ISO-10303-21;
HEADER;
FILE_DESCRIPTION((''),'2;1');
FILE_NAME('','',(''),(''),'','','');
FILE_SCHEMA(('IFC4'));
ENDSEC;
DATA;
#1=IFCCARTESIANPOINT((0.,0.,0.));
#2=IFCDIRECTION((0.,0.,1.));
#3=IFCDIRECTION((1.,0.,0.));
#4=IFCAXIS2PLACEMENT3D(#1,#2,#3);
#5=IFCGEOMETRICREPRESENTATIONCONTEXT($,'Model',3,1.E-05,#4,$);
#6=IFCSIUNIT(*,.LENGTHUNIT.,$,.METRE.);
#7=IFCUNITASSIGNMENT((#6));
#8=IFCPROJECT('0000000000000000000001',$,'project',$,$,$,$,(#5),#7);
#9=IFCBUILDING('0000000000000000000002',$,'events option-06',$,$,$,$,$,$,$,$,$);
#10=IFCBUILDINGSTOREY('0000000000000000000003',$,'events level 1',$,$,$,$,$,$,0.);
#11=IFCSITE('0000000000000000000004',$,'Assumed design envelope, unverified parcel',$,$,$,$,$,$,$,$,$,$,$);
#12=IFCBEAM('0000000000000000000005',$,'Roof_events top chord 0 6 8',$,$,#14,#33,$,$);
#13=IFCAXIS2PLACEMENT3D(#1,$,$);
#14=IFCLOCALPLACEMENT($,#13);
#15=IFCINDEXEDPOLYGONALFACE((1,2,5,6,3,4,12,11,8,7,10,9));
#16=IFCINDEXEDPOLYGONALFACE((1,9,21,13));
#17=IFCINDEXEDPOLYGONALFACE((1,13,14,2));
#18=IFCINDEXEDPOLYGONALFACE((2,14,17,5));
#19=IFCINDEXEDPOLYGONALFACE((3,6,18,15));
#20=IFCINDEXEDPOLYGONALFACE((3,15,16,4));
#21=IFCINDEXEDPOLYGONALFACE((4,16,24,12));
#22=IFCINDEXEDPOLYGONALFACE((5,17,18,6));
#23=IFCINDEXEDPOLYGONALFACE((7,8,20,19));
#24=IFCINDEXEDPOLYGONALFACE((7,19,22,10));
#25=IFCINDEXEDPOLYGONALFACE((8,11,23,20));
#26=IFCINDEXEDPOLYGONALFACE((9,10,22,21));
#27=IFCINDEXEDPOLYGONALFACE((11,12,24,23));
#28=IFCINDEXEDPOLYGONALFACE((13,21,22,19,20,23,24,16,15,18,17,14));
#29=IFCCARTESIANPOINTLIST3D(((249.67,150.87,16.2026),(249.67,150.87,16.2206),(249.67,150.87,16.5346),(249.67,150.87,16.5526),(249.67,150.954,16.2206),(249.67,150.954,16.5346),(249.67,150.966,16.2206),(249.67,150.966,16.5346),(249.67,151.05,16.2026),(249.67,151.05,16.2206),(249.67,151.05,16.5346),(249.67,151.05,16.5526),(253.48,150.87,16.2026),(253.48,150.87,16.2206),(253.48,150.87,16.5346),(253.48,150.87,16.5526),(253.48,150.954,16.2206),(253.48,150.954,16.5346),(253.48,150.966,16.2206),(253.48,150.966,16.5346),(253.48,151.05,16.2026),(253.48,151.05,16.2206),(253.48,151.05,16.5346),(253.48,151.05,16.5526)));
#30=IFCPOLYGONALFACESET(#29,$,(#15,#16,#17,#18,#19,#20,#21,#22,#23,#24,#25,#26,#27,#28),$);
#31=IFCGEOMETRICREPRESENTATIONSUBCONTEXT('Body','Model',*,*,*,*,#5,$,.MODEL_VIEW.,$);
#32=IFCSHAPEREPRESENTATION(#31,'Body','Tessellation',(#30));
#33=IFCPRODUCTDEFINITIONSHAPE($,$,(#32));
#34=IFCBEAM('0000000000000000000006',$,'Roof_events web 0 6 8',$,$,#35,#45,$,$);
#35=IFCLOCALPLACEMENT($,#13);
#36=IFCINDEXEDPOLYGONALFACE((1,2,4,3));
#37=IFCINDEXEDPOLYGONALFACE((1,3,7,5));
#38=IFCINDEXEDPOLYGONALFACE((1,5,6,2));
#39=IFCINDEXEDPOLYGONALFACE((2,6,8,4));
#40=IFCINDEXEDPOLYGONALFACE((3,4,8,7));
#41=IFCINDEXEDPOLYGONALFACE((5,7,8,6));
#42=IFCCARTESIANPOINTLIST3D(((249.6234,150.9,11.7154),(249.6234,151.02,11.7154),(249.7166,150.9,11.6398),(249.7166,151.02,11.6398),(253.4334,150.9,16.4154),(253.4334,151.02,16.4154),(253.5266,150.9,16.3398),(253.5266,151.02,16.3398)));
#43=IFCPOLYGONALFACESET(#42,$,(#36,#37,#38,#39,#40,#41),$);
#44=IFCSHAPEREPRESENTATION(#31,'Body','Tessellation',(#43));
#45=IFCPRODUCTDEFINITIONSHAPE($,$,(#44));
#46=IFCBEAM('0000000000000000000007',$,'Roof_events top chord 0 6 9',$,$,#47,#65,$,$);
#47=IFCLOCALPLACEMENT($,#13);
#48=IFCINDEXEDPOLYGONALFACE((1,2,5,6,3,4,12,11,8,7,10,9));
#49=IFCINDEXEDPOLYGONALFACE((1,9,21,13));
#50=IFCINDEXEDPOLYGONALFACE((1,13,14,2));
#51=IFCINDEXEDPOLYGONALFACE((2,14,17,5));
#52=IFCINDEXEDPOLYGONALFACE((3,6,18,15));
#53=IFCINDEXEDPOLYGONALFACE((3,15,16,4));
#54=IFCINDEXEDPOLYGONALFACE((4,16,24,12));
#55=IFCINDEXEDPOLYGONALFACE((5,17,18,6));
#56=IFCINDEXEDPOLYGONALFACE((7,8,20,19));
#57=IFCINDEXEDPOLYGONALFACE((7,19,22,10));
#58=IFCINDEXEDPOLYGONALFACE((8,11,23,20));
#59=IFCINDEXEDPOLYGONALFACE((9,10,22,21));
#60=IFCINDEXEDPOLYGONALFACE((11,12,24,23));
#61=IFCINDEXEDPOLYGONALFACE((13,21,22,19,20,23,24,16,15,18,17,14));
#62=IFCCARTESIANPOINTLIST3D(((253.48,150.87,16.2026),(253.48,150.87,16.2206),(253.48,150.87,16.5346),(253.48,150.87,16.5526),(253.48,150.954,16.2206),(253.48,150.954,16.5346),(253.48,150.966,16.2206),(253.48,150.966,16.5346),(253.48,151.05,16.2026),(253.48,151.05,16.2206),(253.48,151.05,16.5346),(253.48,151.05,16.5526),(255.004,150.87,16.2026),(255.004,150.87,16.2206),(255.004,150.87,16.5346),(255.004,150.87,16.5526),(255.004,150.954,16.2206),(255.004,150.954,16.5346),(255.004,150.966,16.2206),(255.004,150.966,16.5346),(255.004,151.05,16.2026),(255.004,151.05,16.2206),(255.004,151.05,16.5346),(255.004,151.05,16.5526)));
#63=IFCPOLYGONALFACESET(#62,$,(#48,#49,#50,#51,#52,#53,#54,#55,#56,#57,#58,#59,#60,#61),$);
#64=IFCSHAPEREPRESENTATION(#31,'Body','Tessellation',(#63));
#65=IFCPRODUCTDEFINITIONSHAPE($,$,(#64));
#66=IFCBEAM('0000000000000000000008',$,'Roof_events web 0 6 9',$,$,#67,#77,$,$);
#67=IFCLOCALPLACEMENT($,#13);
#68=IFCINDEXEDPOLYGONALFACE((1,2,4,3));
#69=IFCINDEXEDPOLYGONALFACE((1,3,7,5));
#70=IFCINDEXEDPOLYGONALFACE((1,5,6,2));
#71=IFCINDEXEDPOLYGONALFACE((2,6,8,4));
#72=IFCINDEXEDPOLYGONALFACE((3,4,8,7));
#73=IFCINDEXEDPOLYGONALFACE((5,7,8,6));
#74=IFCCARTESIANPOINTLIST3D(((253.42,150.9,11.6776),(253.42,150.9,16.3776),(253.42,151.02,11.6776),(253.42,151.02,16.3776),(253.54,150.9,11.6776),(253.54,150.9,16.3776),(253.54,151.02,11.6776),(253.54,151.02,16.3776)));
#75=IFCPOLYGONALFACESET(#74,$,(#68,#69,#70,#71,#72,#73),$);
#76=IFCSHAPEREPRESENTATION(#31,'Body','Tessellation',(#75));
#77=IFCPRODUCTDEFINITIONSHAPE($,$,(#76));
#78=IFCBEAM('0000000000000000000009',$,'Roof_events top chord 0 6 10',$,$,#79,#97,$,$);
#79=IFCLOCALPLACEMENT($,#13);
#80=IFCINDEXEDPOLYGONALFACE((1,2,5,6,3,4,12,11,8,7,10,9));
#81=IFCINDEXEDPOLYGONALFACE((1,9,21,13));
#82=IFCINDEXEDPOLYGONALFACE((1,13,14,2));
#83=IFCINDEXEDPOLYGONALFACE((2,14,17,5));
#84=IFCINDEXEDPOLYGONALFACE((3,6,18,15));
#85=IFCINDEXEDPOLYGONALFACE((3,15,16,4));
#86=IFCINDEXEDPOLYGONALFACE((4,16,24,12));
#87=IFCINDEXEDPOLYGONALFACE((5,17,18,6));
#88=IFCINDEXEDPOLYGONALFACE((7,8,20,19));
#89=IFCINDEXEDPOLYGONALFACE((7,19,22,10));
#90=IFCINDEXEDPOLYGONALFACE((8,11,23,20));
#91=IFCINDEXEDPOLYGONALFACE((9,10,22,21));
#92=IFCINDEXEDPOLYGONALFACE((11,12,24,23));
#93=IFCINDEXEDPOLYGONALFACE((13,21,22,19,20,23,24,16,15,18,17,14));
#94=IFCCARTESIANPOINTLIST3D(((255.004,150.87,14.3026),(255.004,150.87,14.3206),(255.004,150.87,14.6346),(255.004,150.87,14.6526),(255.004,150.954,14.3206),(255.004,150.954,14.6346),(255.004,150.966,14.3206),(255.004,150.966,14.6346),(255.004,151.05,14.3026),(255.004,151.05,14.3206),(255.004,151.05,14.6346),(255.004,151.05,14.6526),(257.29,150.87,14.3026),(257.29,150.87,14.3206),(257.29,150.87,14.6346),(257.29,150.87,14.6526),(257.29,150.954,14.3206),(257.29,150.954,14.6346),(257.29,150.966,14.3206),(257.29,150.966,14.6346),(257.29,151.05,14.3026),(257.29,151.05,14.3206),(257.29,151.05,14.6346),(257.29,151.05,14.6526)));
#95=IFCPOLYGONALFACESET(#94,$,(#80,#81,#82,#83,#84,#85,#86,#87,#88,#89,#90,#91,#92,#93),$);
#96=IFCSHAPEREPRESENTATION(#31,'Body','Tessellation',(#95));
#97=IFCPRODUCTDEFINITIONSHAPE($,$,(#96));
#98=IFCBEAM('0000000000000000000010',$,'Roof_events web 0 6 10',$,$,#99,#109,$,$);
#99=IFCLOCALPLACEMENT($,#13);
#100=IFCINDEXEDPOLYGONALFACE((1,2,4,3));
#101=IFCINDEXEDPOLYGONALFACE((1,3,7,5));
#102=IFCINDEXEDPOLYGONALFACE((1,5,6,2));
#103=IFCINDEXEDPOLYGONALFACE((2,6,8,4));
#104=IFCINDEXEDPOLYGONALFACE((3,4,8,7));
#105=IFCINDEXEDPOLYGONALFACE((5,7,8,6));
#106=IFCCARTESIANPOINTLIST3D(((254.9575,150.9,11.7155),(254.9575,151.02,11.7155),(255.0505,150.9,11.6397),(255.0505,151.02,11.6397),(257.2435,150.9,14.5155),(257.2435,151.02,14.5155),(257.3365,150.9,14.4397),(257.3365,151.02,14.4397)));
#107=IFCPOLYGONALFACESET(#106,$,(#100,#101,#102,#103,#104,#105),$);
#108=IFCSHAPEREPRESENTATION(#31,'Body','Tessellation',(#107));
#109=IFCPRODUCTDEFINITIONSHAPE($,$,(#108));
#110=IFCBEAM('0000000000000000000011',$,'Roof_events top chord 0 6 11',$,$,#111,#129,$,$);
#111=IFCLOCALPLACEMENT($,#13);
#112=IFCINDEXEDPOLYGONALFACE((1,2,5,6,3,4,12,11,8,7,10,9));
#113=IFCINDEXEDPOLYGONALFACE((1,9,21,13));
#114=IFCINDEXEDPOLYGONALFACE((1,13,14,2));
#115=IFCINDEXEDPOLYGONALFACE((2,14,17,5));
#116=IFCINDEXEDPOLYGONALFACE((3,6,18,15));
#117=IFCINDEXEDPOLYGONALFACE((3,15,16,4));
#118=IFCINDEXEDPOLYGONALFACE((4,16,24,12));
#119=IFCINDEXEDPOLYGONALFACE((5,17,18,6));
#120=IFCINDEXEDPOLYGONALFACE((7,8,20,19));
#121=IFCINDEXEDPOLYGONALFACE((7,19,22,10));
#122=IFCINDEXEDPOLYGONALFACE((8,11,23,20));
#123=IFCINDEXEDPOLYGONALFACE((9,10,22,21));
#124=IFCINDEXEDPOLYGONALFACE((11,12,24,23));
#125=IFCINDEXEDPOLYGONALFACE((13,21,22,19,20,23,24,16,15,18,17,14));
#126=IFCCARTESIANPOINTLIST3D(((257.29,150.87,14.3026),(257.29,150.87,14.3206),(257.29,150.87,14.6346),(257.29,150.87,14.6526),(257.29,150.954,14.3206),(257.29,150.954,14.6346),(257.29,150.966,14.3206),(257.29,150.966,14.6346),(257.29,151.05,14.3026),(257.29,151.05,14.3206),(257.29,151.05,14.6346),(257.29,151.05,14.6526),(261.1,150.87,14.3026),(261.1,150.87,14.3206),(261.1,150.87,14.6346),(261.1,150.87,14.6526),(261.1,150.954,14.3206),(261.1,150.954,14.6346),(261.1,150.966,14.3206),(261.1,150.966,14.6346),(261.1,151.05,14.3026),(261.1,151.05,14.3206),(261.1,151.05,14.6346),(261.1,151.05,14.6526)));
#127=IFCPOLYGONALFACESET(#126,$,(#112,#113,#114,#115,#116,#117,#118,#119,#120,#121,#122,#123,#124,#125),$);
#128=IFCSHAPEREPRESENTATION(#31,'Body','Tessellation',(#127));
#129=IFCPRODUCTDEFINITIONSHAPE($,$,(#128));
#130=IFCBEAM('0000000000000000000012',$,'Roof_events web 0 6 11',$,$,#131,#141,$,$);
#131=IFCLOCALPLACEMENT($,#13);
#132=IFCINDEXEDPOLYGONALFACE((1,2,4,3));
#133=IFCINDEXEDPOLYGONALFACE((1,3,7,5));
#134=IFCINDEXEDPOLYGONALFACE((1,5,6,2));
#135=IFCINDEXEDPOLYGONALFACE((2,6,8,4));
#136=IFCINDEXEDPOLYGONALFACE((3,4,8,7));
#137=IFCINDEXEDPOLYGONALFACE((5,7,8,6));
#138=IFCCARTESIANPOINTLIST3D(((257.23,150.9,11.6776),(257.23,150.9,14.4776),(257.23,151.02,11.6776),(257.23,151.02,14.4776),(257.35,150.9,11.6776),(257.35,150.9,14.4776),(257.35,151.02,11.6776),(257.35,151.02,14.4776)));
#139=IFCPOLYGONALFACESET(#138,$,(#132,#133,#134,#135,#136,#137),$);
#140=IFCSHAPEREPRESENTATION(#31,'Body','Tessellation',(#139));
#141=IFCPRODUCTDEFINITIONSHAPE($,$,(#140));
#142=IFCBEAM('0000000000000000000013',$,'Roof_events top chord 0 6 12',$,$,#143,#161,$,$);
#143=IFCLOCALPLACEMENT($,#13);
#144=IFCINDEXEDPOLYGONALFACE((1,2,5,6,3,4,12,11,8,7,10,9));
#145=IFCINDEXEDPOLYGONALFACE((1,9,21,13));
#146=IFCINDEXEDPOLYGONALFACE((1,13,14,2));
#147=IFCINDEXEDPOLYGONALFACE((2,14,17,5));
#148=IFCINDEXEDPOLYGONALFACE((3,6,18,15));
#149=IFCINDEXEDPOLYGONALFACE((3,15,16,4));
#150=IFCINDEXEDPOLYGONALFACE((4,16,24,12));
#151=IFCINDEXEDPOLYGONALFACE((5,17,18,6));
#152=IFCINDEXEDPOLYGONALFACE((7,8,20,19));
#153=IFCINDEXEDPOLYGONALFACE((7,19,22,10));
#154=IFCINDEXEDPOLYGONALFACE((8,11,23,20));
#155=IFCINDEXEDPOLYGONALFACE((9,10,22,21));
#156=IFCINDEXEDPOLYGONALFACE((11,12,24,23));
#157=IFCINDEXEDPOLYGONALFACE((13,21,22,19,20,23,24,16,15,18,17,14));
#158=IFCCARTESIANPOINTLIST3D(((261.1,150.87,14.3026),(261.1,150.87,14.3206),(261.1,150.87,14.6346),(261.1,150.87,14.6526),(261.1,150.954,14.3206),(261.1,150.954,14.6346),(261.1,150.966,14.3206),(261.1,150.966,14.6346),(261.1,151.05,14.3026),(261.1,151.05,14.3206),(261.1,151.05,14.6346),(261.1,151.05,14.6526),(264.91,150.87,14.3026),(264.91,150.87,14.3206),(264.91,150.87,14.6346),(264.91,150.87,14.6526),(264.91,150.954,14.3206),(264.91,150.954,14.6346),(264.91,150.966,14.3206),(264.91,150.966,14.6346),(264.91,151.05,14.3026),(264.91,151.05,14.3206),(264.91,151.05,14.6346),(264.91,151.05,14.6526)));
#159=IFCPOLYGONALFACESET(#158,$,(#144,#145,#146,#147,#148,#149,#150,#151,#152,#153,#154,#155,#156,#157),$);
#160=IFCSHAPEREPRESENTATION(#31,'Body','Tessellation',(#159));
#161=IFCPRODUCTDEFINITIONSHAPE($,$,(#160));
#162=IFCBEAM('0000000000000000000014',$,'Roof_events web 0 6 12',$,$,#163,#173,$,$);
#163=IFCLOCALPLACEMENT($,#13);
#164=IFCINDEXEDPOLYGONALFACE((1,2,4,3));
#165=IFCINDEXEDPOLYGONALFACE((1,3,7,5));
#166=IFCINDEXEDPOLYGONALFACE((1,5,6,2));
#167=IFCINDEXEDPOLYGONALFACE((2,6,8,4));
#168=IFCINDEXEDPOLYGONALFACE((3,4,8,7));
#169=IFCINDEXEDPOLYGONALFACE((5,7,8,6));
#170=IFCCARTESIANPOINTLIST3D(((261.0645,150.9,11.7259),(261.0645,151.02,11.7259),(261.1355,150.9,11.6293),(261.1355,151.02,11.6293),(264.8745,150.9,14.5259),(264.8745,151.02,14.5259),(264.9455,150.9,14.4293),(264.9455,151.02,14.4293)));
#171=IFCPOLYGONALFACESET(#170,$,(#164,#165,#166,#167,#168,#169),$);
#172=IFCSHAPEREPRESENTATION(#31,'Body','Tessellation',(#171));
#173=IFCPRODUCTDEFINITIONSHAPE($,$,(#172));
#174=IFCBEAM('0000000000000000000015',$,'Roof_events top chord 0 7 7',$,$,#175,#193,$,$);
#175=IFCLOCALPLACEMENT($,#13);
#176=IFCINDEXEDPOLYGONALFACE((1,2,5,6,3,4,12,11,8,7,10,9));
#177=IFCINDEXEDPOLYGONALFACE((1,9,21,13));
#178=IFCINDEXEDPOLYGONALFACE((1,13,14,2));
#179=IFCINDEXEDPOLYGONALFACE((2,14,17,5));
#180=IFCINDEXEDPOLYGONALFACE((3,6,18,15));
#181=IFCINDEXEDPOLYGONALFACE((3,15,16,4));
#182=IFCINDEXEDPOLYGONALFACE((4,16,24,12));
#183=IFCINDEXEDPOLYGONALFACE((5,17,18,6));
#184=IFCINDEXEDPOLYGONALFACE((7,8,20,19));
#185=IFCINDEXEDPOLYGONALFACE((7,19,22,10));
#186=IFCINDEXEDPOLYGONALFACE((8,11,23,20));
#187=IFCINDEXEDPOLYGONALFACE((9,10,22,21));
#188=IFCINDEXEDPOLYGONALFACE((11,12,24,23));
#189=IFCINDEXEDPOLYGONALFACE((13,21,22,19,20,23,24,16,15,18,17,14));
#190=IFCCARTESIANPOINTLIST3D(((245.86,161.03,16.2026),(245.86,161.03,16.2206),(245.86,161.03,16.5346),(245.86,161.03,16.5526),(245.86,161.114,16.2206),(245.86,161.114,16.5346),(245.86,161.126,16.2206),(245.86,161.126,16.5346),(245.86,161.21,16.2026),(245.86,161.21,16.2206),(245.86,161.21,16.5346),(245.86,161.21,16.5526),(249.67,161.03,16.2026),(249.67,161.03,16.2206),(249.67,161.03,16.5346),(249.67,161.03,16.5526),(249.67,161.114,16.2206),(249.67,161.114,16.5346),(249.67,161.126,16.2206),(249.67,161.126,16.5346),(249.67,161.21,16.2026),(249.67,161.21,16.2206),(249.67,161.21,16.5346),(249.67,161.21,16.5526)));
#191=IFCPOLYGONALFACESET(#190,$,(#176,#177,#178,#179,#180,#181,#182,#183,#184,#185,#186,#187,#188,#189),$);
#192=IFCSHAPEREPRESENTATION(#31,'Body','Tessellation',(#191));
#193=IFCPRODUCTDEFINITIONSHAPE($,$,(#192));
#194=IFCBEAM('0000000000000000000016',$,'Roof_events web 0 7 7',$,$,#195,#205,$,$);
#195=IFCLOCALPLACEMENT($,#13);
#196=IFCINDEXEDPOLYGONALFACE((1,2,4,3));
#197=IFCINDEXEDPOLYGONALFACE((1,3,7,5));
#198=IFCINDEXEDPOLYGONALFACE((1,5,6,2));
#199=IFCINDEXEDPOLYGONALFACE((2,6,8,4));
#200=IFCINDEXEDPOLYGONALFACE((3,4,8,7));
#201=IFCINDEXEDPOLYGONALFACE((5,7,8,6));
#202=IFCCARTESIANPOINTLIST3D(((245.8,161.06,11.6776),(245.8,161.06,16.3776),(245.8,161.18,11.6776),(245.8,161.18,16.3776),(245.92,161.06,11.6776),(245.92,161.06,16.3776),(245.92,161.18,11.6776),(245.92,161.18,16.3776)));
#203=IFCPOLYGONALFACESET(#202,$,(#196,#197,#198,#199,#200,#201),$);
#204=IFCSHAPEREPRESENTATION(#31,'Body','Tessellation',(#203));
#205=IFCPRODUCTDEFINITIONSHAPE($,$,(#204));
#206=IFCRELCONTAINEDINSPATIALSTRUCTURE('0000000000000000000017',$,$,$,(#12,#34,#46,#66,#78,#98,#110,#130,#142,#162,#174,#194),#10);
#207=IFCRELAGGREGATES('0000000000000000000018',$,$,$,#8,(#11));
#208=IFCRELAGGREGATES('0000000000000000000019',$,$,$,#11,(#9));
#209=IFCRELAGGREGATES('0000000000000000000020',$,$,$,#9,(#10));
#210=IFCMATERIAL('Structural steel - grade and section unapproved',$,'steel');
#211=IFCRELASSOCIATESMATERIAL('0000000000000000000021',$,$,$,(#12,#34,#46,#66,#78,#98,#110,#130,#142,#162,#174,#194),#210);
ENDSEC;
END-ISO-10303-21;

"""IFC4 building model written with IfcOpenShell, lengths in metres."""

from ifc_helpers import new_model, si_unit, frame, origin_with_axes, place, context, subcontext, project, spatial, rectangle, i_section, extrude, material, element, save


model = new_model("IFC4")

# Units and contexts
model_context = context("Model", 3, precision=1e-05, world=origin_with_axes())
body_context = subcontext(model_context, "Body", "Model", "MODEL_VIEW")
ifc_project = project(units=[si_unit("LENGTHUNIT", "METRE")], contexts=[model_context])

# Site, building, storey
site = spatial("IfcSite", under=ifc_project, Name="Assumed design envelope, unverified parcel")
building = spatial("IfcBuilding", under=site, Name="events option-06")
storey = spatial("IfcBuildingStorey", under=building, Name="events level 1", Elevation=0.0)

# Beams
ifc_material = material(Name="Structural steel - grade and section unapproved", Category="steel")
beam_1_placement = place(None, frame((249.67, 150.96, 16.3776), z_axis=(1.0, 0.0, 0.0), x_axis=(0.0, 1.0, 0.0)))
element("IfcBeam", 1, at=beam_1_placement, inside=storey, material=ifc_material, Name="Roof_events top chord 0 6 8", context=body_context, shape_type="SweptSolid", body=[
    extrude(i_section(OverallWidth=0.18, OverallDepth=0.35, WebThickness=0.012, FlangeThickness=0.018, FilletRadius=0.0), origin_with_axes(), (0.0, 0.0, 1.0), 3.81),
])
beam_2_placement = place(None, frame((249.67, 150.96, 11.6776), z_axis=(0.629721, 0.0, 0.776821), x_axis=(0.0, 1.0, 0.0)))
element("IfcBeam", 2, at=beam_2_placement, inside=storey, material=ifc_material, Name="Roof_events web 0 6 8", context=body_context, shape_type="SweptSolid", body=[
    extrude(rectangle(XDim=0.12, YDim=0.12), origin_with_axes(), (0.0, 0.0, 1.0), 6.0503),
])
beam_3_placement = place(None, frame((253.48, 150.96, 16.3776), z_axis=(1.0, 0.0, 0.0), x_axis=(0.0, 1.0, 0.0)))
element("IfcBeam", 3, at=beam_3_placement, inside=storey, material=ifc_material, Name="Roof_events top chord 0 6 9", context=body_context, shape_type="SweptSolid", body=[
    extrude(i_section(OverallWidth=0.18, OverallDepth=0.35, WebThickness=0.012, FlangeThickness=0.018, FilletRadius=0.0), origin_with_axes(), (0.0, 0.0, 1.0), 1.524),
])
beam_4_placement = place(None, frame((253.48, 150.96, 11.6776), z_axis=(0.0, 0.0, 1.0), x_axis=(-1.0, 0.0, 0.0)))
element("IfcBeam", 4, at=beam_4_placement, inside=storey, material=ifc_material, Name="Roof_events web 0 6 9", context=body_context, shape_type="SweptSolid", body=[
    extrude(rectangle(XDim=0.12, YDim=0.12), origin_with_axes(), (0.0, 0.0, 1.0), 4.7),
])
beam_5_placement = place(None, frame((255.004, 150.96, 14.4776), z_axis=(1.0, 0.0, 0.0), x_axis=(0.0, 1.0, 0.0)))
element("IfcBeam", 5, at=beam_5_placement, inside=storey, material=ifc_material, Name="Roof_events top chord 0 6 10", context=body_context, shape_type="SweptSolid", body=[
    extrude(i_section(OverallWidth=0.18, OverallDepth=0.35, WebThickness=0.012, FlangeThickness=0.018, FilletRadius=0.0), origin_with_axes(), (0.0, 0.0, 1.0), 2.286),
])
beam_6_placement = place(None, frame((255.004, 150.96, 11.6776), z_axis=(0.632426, 0.0, 0.774621), x_axis=(0.0, 1.0, 0.0)))
element("IfcBeam", 6, at=beam_6_placement, inside=storey, material=ifc_material, Name="Roof_events web 0 6 10", context=body_context, shape_type="SweptSolid", body=[
    extrude(rectangle(XDim=0.12, YDim=0.12), origin_with_axes(), (0.0, 0.0, 1.0), 3.6147),
])
beam_7_placement = place(None, frame((257.29, 150.96, 14.4776), z_axis=(1.0, 0.0, 0.0), x_axis=(0.0, 1.0, 0.0)))
element("IfcBeam", 7, at=beam_7_placement, inside=storey, material=ifc_material, Name="Roof_events top chord 0 6 11", context=body_context, shape_type="SweptSolid", body=[
    extrude(i_section(OverallWidth=0.18, OverallDepth=0.35, WebThickness=0.012, FlangeThickness=0.018, FilletRadius=0.0), origin_with_axes(), (0.0, 0.0, 1.0), 3.81),
])
beam_8_placement = place(None, frame((257.29, 150.96, 11.6776), z_axis=(0.0, 0.0, 1.0), x_axis=(-1.0, 0.0, 0.0)))
element("IfcBeam", 8, at=beam_8_placement, inside=storey, material=ifc_material, Name="Roof_events web 0 6 11", context=body_context, shape_type="SweptSolid", body=[
    extrude(rectangle(XDim=0.12, YDim=0.12), origin_with_axes(), (0.0, 0.0, 1.0), 2.8),
])
beam_9_placement = place(None, frame((261.1, 150.96, 14.4776), z_axis=(1.0, 0.0, 0.0), x_axis=(0.0, 1.0, 0.0)))
element("IfcBeam", 9, at=beam_9_placement, inside=storey, material=ifc_material, Name="Roof_events top chord 0 6 12", context=body_context, shape_type="SweptSolid", body=[
    extrude(i_section(OverallWidth=0.18, OverallDepth=0.35, WebThickness=0.012, FlangeThickness=0.018, FilletRadius=0.0), origin_with_axes(), (0.0, 0.0, 1.0), 3.81),
])
beam_10_placement = place(None, frame((261.1, 150.96, 11.6776), z_axis=(0.805799, 0.0, 0.592189), x_axis=(0.0, 1.0, 0.0)))
element("IfcBeam", 10, at=beam_10_placement, inside=storey, material=ifc_material, Name="Roof_events web 0 6 12", context=body_context, shape_type="SweptSolid", body=[
    extrude(rectangle(XDim=0.12, YDim=0.12), origin_with_axes(), (0.0, 0.0, 1.0), 4.7282),
])
beam_11_placement = place(None, frame((245.86, 161.12, 16.3776), z_axis=(1.0, 0.0, 0.0), x_axis=(0.0, 1.0, 0.0)))
element("IfcBeam", 11, at=beam_11_placement, inside=storey, material=ifc_material, Name="Roof_events top chord 0 7 7", context=body_context, shape_type="SweptSolid", body=[
    extrude(i_section(OverallWidth=0.18, OverallDepth=0.35, WebThickness=0.012, FlangeThickness=0.018, FilletRadius=0.0), origin_with_axes(), (0.0, 0.0, 1.0), 3.81),
])
beam_12_placement = place(None, frame((245.86, 161.12, 11.6776), z_axis=(0.0, 0.0, 1.0), x_axis=(-1.0, 0.0, 0.0)))
element("IfcBeam", 12, at=beam_12_placement, inside=storey, material=ifc_material, Name="Roof_events web 0 7 7", context=body_context, shape_type="SweptSolid", body=[
    extrude(rectangle(XDim=0.12, YDim=0.12), origin_with_axes(), (0.0, 0.0, 1.0), 4.7),
])

save(model, "model.ifc")
